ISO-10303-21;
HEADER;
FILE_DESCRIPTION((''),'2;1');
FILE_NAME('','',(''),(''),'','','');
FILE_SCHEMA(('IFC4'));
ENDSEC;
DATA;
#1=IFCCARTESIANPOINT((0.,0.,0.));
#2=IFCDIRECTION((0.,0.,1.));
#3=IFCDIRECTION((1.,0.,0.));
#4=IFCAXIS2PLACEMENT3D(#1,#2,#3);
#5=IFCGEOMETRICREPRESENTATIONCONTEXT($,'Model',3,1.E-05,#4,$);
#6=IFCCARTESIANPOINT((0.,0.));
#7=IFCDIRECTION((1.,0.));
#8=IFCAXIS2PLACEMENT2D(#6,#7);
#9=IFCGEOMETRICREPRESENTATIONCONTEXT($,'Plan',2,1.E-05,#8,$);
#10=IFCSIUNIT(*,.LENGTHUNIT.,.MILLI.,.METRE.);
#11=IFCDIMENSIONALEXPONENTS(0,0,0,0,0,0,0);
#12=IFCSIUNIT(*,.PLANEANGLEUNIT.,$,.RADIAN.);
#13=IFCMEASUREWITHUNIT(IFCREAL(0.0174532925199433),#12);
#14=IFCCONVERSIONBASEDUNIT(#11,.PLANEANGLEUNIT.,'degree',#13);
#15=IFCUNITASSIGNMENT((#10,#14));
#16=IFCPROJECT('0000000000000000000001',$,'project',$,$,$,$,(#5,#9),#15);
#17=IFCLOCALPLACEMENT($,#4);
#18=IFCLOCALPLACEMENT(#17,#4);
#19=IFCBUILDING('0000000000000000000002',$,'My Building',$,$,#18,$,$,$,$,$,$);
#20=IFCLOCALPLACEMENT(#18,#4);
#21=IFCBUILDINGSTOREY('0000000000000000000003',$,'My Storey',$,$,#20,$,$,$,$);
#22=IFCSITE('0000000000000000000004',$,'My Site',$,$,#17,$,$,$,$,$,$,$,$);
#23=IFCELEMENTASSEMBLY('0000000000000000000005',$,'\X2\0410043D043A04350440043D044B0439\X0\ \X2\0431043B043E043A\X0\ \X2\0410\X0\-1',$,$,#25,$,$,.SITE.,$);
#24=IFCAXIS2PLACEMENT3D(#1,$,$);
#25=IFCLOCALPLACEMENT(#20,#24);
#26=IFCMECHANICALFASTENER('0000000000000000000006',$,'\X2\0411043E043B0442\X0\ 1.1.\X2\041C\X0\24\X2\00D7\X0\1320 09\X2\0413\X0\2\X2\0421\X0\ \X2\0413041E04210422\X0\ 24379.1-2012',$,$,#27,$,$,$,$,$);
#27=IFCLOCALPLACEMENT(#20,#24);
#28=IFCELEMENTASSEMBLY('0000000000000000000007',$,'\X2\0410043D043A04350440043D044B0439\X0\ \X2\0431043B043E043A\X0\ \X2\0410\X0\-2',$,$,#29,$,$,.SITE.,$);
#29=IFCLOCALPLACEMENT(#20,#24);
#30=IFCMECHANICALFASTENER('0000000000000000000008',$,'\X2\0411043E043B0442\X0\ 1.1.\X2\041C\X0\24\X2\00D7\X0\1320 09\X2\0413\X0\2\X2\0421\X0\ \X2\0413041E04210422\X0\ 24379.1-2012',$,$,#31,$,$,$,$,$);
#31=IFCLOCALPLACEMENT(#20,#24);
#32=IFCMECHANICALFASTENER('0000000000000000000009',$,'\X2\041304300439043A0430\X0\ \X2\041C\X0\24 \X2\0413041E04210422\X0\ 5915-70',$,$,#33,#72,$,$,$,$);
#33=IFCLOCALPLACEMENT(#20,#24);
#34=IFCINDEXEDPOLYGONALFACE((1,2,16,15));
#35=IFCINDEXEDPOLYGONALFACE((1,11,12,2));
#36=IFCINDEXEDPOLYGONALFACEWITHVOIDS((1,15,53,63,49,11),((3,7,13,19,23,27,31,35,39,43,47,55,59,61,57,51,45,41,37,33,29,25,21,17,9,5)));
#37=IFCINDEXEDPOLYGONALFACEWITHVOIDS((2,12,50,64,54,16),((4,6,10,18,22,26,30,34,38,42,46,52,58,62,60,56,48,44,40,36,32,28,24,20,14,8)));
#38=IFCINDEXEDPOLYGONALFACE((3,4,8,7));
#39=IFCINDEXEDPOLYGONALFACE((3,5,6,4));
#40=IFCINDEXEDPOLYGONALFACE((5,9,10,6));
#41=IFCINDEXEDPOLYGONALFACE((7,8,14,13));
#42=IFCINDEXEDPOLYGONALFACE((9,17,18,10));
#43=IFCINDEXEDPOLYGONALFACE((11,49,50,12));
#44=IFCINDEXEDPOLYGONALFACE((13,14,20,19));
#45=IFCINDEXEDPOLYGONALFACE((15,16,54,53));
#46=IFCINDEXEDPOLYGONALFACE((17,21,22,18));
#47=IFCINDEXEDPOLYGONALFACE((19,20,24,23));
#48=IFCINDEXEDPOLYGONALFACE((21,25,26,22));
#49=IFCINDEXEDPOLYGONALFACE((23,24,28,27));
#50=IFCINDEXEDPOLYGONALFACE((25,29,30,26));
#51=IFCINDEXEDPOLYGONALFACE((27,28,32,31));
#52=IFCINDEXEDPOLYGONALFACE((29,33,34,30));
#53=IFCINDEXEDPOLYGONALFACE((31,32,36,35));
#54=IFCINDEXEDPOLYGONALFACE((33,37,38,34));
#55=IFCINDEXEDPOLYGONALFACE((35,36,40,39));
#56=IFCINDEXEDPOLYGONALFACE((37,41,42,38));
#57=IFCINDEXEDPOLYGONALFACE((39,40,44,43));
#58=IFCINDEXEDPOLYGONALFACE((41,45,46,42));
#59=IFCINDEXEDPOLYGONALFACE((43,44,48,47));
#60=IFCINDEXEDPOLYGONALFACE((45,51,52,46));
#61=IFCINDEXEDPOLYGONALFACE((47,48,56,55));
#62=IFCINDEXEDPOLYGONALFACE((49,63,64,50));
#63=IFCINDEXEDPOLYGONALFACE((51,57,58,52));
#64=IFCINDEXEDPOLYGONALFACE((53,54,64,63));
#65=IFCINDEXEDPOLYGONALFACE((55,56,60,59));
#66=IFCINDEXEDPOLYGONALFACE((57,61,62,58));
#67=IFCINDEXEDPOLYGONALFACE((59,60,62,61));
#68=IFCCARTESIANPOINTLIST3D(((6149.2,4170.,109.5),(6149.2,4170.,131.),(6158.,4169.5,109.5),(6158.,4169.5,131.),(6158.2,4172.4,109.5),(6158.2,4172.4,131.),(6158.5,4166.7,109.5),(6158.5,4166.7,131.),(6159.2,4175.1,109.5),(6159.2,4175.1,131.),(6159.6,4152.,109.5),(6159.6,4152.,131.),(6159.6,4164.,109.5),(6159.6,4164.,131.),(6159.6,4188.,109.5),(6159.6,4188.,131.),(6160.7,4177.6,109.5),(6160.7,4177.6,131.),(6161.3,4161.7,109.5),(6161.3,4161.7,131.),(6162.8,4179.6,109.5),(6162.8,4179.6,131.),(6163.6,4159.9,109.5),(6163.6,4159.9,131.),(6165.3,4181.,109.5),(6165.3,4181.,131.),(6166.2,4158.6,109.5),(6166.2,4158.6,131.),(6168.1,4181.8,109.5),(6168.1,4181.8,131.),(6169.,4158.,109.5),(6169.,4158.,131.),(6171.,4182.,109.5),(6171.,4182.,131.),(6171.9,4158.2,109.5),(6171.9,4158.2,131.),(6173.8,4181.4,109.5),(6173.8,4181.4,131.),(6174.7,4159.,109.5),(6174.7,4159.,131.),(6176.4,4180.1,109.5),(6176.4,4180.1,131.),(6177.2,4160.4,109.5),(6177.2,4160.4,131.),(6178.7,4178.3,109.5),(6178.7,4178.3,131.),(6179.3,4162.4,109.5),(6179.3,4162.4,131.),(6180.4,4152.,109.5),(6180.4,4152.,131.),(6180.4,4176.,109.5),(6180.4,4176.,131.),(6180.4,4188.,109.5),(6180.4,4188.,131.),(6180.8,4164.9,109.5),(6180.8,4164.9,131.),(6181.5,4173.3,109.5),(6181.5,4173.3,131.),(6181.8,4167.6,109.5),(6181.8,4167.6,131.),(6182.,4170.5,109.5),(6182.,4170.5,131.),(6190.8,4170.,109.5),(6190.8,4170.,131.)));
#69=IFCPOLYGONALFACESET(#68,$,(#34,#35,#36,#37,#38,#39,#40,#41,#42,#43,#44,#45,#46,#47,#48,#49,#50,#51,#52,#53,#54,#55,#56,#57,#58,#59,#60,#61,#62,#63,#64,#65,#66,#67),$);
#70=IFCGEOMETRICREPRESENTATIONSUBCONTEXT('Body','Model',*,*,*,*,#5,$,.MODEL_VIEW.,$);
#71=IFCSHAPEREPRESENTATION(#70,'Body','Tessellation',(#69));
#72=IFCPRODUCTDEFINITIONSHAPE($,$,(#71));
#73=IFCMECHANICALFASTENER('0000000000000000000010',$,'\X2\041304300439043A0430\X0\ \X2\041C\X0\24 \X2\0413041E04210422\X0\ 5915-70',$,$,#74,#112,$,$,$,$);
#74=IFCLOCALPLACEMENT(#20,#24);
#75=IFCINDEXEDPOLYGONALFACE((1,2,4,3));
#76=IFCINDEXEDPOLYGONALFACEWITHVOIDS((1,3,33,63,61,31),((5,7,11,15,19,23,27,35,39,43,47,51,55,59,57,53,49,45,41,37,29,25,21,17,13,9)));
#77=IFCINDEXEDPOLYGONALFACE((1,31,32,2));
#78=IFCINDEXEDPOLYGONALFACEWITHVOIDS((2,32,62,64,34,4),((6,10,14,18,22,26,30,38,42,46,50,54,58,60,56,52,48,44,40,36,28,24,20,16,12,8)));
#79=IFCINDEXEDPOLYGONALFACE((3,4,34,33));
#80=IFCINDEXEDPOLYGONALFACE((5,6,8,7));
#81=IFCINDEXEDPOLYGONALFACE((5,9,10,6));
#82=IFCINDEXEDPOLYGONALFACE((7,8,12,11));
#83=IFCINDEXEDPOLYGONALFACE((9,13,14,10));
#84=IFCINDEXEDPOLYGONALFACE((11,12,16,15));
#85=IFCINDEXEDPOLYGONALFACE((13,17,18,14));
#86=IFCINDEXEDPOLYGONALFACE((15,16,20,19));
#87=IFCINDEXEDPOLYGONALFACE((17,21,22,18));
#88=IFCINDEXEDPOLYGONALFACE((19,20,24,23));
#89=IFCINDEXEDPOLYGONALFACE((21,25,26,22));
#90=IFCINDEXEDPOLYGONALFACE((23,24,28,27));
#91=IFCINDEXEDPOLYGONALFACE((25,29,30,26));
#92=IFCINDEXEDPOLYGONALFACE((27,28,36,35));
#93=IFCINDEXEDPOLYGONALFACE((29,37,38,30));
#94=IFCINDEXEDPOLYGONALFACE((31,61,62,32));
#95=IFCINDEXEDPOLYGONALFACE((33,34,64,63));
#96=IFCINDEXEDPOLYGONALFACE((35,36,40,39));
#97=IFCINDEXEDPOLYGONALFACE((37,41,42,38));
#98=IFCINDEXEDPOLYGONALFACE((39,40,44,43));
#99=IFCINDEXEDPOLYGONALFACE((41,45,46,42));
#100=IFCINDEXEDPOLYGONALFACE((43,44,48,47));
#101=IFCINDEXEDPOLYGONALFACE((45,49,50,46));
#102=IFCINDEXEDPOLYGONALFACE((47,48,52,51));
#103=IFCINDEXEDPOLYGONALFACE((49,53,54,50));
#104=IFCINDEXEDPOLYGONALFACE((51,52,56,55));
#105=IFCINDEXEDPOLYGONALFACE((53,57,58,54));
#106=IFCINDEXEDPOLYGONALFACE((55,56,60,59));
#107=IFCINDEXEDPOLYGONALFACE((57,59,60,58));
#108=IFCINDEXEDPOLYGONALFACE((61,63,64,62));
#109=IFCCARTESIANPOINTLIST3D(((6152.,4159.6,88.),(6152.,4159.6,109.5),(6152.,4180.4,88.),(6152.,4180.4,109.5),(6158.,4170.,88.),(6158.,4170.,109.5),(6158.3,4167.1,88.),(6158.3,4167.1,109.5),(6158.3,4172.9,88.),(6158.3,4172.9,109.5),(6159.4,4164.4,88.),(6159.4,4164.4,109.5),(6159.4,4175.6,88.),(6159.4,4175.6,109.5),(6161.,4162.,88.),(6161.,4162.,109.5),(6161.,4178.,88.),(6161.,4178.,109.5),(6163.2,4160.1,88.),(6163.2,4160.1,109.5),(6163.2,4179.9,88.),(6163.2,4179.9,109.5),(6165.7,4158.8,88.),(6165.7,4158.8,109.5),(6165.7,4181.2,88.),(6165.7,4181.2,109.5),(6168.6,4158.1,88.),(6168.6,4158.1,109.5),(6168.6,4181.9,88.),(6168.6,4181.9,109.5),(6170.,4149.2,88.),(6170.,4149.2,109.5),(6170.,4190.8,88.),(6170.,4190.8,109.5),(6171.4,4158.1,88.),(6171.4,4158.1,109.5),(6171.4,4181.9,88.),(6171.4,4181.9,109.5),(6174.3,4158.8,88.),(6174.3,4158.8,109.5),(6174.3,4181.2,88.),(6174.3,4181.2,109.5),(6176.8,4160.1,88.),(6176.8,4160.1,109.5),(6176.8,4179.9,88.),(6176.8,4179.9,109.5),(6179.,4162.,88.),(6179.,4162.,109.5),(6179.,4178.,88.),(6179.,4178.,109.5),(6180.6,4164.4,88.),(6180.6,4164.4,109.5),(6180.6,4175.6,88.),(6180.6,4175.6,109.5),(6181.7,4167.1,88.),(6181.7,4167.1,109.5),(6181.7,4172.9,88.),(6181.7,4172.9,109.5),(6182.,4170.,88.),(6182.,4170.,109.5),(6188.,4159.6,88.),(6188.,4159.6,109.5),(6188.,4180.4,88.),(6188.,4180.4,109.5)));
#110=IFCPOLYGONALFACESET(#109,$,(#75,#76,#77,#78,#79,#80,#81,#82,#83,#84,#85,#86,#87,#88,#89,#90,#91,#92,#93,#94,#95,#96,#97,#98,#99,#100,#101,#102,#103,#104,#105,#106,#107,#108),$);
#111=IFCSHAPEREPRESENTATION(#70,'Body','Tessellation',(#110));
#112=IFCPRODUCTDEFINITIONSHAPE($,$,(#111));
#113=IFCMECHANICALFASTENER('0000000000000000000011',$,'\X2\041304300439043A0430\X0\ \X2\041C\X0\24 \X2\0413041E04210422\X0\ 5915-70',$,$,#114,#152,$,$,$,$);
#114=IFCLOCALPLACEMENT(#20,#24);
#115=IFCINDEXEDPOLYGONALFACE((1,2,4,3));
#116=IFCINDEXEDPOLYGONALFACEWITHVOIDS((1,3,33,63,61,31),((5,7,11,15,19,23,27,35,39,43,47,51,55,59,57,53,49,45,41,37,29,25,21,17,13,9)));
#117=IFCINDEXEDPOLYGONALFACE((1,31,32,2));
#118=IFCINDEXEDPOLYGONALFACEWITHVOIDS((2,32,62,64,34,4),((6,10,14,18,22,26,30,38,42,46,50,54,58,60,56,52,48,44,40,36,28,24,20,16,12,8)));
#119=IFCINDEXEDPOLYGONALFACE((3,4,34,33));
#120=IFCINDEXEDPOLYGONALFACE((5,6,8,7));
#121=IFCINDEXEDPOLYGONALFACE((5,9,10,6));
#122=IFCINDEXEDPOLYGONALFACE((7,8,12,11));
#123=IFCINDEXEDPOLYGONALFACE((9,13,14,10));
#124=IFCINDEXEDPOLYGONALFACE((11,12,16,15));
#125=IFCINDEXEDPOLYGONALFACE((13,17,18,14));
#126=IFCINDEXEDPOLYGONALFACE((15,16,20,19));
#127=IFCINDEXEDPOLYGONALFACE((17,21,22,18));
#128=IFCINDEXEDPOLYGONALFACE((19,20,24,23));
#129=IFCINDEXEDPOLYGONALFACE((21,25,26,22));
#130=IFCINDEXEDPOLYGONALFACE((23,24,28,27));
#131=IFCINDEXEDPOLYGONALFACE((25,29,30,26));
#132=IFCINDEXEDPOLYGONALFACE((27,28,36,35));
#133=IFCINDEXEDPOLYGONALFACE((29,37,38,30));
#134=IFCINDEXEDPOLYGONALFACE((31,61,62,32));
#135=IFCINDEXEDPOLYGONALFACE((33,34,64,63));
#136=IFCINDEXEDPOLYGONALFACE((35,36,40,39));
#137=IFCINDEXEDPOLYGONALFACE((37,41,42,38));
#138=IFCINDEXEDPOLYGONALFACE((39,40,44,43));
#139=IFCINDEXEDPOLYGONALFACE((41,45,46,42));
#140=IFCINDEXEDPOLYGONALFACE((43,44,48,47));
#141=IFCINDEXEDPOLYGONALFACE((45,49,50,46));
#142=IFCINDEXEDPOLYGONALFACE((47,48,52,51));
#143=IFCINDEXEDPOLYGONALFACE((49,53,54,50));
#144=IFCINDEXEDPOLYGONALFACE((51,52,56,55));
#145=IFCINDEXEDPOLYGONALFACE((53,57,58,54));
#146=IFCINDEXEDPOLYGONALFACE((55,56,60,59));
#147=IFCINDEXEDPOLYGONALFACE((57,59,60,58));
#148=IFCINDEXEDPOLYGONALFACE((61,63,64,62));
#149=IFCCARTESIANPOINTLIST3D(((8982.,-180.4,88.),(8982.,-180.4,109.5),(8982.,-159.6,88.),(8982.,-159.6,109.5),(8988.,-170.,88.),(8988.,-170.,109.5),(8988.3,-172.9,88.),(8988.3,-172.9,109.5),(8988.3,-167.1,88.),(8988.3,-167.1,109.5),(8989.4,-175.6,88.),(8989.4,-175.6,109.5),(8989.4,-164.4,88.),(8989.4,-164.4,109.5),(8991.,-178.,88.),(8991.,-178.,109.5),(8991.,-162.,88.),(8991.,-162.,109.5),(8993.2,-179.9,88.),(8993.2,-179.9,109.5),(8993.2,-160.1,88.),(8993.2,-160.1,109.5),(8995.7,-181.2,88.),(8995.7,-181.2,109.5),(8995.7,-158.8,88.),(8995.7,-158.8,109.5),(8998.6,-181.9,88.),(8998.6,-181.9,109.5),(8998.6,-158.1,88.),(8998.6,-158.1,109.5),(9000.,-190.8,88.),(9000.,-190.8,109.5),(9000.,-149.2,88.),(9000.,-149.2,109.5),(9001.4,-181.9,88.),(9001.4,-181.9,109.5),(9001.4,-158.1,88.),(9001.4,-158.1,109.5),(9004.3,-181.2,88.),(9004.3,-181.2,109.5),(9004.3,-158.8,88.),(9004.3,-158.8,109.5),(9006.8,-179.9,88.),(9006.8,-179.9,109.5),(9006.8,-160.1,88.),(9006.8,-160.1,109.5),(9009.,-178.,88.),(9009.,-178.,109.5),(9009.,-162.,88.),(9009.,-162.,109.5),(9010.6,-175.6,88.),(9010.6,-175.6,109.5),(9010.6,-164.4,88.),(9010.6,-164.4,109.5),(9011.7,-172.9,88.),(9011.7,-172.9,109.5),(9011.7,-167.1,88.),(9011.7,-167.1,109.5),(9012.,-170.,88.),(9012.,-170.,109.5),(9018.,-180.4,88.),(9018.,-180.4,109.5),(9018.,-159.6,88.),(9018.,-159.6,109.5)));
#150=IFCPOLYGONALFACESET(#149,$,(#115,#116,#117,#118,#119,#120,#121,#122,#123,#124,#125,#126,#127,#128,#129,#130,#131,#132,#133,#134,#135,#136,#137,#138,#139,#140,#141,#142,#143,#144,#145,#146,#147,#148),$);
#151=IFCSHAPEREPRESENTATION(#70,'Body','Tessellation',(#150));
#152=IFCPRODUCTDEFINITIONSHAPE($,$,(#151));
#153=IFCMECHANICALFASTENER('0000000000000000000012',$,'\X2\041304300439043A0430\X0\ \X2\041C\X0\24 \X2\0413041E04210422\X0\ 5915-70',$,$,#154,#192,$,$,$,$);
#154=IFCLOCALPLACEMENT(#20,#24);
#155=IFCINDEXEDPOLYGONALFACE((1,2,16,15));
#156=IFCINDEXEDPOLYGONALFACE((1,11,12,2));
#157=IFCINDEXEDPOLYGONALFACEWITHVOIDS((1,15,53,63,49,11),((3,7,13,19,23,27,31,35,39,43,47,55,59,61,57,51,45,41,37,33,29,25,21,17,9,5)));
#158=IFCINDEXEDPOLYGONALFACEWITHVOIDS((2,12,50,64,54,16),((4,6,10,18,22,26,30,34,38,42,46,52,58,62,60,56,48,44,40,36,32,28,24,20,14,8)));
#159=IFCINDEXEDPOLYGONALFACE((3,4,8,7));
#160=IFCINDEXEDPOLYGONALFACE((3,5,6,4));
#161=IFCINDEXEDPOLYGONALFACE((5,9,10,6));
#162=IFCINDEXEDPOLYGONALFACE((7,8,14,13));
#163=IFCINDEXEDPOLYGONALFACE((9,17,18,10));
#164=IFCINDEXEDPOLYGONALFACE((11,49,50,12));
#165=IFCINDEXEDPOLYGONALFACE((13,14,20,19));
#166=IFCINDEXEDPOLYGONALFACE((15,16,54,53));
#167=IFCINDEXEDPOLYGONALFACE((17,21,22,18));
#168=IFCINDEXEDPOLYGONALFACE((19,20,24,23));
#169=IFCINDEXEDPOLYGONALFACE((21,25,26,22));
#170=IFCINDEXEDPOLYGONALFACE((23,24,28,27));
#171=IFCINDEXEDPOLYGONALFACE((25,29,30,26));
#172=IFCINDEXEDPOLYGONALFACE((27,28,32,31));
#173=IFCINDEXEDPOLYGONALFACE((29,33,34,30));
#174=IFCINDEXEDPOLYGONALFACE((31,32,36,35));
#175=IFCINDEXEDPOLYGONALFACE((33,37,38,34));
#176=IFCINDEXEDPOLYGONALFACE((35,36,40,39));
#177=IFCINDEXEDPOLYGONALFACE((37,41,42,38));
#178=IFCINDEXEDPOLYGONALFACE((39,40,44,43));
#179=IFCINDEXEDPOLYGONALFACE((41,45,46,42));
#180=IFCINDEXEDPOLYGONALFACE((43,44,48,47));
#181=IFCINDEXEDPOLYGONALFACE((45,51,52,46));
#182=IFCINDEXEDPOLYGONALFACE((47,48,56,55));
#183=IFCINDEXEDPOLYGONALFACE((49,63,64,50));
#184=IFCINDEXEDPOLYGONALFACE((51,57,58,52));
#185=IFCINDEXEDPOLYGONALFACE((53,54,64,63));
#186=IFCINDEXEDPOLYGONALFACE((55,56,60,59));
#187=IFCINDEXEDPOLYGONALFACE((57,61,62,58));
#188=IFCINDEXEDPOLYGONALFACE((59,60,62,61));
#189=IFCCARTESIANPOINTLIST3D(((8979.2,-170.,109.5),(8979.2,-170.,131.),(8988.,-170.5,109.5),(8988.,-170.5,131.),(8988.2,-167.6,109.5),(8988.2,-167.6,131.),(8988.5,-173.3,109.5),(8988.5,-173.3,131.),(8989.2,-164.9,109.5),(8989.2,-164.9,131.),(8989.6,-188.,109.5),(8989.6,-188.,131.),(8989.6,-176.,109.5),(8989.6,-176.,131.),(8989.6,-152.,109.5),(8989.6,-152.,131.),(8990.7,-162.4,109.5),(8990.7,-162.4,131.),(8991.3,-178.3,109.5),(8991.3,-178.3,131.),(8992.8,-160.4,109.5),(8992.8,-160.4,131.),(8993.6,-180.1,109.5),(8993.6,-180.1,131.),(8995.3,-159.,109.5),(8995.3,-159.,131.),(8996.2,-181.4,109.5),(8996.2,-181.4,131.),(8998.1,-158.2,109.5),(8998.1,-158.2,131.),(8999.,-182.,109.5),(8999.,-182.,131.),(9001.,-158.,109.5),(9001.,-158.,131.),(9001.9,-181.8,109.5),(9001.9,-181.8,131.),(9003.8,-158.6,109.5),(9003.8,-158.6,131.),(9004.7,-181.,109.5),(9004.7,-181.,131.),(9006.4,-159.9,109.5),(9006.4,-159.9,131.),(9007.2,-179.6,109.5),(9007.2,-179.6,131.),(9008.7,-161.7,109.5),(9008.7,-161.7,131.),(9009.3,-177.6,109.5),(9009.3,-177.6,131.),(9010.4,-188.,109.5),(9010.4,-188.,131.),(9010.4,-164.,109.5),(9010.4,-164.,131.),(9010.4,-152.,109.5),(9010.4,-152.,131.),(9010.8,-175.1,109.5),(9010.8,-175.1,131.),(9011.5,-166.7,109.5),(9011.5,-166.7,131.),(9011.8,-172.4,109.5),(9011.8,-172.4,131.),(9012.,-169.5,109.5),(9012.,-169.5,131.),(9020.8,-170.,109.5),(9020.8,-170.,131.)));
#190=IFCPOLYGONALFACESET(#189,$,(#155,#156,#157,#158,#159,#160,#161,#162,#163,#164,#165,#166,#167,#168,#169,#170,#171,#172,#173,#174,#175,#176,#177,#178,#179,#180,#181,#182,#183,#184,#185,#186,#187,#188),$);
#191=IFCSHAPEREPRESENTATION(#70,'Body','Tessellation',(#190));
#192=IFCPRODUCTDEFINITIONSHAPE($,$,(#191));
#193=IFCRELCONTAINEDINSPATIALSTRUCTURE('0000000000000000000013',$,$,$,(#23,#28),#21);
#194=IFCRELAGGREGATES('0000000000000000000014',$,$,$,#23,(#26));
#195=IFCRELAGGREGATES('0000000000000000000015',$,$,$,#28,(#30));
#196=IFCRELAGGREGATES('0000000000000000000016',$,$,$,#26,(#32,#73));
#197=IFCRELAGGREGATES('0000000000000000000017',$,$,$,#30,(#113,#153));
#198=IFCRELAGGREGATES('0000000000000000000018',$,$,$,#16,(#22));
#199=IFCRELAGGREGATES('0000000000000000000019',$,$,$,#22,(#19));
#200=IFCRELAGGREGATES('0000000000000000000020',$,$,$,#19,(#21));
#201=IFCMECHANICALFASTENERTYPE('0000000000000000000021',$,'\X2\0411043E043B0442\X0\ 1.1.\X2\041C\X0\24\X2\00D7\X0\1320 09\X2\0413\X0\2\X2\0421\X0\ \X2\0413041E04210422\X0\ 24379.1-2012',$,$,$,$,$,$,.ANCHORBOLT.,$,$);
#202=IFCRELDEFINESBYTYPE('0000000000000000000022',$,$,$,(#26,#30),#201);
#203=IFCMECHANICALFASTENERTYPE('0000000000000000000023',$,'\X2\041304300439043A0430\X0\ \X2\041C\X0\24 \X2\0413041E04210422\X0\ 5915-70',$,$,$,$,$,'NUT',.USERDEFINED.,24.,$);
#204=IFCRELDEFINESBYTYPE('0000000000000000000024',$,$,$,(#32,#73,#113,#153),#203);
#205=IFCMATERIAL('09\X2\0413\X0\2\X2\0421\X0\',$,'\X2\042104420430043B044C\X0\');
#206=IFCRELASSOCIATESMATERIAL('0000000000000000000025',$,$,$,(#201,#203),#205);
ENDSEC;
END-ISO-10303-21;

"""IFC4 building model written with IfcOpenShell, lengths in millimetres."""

from ifc_helpers import new_model, entity, si_unit, converted_unit, frame, origin_with_axes, origin_2d_with_axis, place, context, subcontext, project, spatial, polyline, outline, extrude, source, transform, mapped, material, type_object, type_shapes, element, aggregate, save


model = new_model("IFC4")

# Units and contexts
model_context = context("Model", 3, precision=1e-05, world=origin_with_axes())
plan_context = context("Plan", 2, precision=1e-05, world=origin_2d_with_axis())
body_context = subcontext(model_context, "Body", "Model", "MODEL_VIEW")
ifc_project = project(units=[si_unit("LENGTHUNIT", "METRE", prefix="MILLI"), converted_unit("PLANEANGLEUNIT", "degree", entity("IfcReal", 0.0174532925199433), si_unit("PLANEANGLEUNIT", "RADIAN"), dimensions=[0, 0, 0, 0, 0, 0, 0])], contexts=[model_context, plan_context])

# Site, building, storey
site_placement = place(None, origin_with_axes())
site = spatial("IfcSite", under=ifc_project, at=site_placement, Name="My Site")
building_placement = place(site_placement, origin_with_axes())
building = spatial("IfcBuilding", under=site, at=building_placement, Name="My Building")
storey_placement = place(building_placement, origin_with_axes())
storey = spatial("IfcBuildingStorey", under=building, at=storey_placement, Name="My Storey")

# Element assemblies, mechanical fasteners
assembly_1_placement = place(storey_placement, frame((6000.0, 4000.0, 0.0), z_axis=(0.0, 0.0, 1.0), x_axis=(1.0, 0.0, 0.0)))
assembly_1 = element("IfcElementAssembly", 1, at=assembly_1_placement, inside=storey, Name="Анкерный блок А-1", AssemblyPlace="SITE")
ifc_material_1 = material(Name="09Г2С", Category="Сталь")
mechanical_fastener_type_1 = type_object("IfcMechanicalFastenerType", Name="Болт 1.1.М24×1320 09Г2С ГОСТ 24379.1-2012", PredefinedType="ANCHORBOLT", material=ifc_material_1)
mechanical_fastener_1_placement = place(assembly_1_placement, frame((170.0, 170.0, 0.0), z_axis=(0.0, 0.0, 1.0), x_axis=(-1.0, 0.0, 0.0)))
mechanical_fastener_1 = element("IfcMechanicalFastener", 2, at=mechanical_fastener_1_placement, type_object=mechanical_fastener_type_1, Name="Болт 1.1.М24×1320 09Г2С ГОСТ 24379.1-2012")
aggregate(assembly_1, [mechanical_fastener_1])
assembly_2_placement = place(storey_placement, frame((9000.0, 0.0, 0.0), z_axis=(0.0, 0.0, 1.0), x_axis=(1.0, 0.0, 0.0)))
assembly_2 = element("IfcElementAssembly", 3, at=assembly_2_placement, inside=storey, Name="Анкерный блок А-2", AssemblyPlace="SITE")
mechanical_fastener_2_placement = place(assembly_2_placement, frame((0.0, -170.0, 0.0), z_axis=(0.0, 0.0, 1.0), x_axis=(1.0, 0.0, 0.0)))
mechanical_fastener_2 = element("IfcMechanicalFastener", 4, at=mechanical_fastener_2_placement, type_object=mechanical_fastener_type_1, Name="Болт 1.1.М24×1320 09Г2С ГОСТ 24379.1-2012")
aggregate(assembly_2, [mechanical_fastener_2])
mechanical_fastener_type_2 = type_object("IfcMechanicalFastenerType", Name="Гайка М24 ГОСТ 5915-70", ElementType="NUT", NominalDiameter=24.0, PredefinedType="USERDEFINED", material=ifc_material_1)
shared_shape_1 = source(origin_with_axes(), body_context, "Body", "SweptSolid", [
    extrude(outline(polyline([(-10.4, -18.0), (10.4, -18.0), (20.8, 0.0), (10.4, 18.0), (-10.4, 18.0), (-20.8, 0.0), (-10.4, -18.0)]), holes=[polyline([(-8.0, 9.0), (-5.6, 10.6), (-2.9, 11.7), (0.0, 12.0), (2.9, 11.7), (5.6, 10.6), (8.0, 9.0), (9.9, 6.8), (11.2, 4.3), (11.9, 1.4), (11.9, -1.4), (11.2, -4.3), (9.9, -6.8), (8.0, -9.0), (5.6, -10.6), (2.9, -11.7), (0.0, -12.0), (-2.9, -11.7), (-5.6, -10.6), (-8.0, -9.0), (-9.9, -6.8), (-11.2, -4.3), (-11.9, -1.4), (-11.9, 1.4), (-11.2, 4.3), (-9.9, 6.8), (-8.0, 9.0)])]), frame((0.0, 0.0, 0.0), z_axis=(0.0, 0.0, 1.0), x_axis=(0.0, 1.0, 0.0)), (0.0, 0.0, 1.0), 21.5),
])
type_shapes(mechanical_fastener_type_2, [shared_shape_1])

# Mechanical fasteners
mechanical_fastener_3_placement = place(mechanical_fastener_1_placement, frame((0.0, 0.0, 109.5), z_axis=(0.0, 0.0, 1.0), x_axis=(0.866025, 0.5, 0.0)))
mechanical_fastener_3 = element("IfcMechanicalFastener", 5, at=mechanical_fastener_3_placement, type_object=mechanical_fastener_type_2, Name="Гайка М24 ГОСТ 5915-70", context=body_context, shape_type="MappedRepresentation", body=[
    mapped(shared_shape_1, transform((0.0, 0.0, 0.0), x_axis=(1.0, 0.0, 0.0), y_axis=(0.0, 1.0, 0.0), z_axis=(0.0, 0.0, 1.0), scale=1.0)),
])
mechanical_fastener_4_placement = place(mechanical_fastener_1_placement, frame((0.0, 0.0, 88.0), z_axis=(0.0, 0.0, 1.0), x_axis=(1.0, 0.0, 0.0)))
mechanical_fastener_4 = element("IfcMechanicalFastener", 6, at=mechanical_fastener_4_placement, type_object=mechanical_fastener_type_2, Name="Гайка М24 ГОСТ 5915-70", context=body_context, shape_type="MappedRepresentation", body=[
    mapped(shared_shape_1, transform((0.0, 0.0, 0.0), x_axis=(1.0, 0.0, 0.0), y_axis=(0.0, 1.0, 0.0), z_axis=(0.0, 0.0, 1.0), scale=1.0)),
])
mechanical_fastener_5_placement = place(mechanical_fastener_2_placement, frame((0.0, 0.0, 88.0), z_axis=(0.0, 0.0, 1.0), x_axis=(1.0, 0.0, 0.0)))
mechanical_fastener_5 = element("IfcMechanicalFastener", 7, at=mechanical_fastener_5_placement, type_object=mechanical_fastener_type_2, Name="Гайка М24 ГОСТ 5915-70", context=body_context, shape_type="MappedRepresentation", body=[
    mapped(shared_shape_1, transform((0.0, 0.0, 0.0), x_axis=(1.0, 0.0, 0.0), y_axis=(0.0, 1.0, 0.0), z_axis=(0.0, 0.0, 1.0), scale=1.0)),
])
mechanical_fastener_6_placement = place(mechanical_fastener_2_placement, frame((0.0, 0.0, 109.5), z_axis=(0.0, 0.0, 1.0), x_axis=(0.866025, 0.5, 0.0)))
mechanical_fastener_6 = element("IfcMechanicalFastener", 8, at=mechanical_fastener_6_placement, type_object=mechanical_fastener_type_2, Name="Гайка М24 ГОСТ 5915-70", context=body_context, shape_type="MappedRepresentation", body=[
    mapped(shared_shape_1, transform((0.0, 0.0, 0.0), x_axis=(1.0, 0.0, 0.0), y_axis=(0.0, 1.0, 0.0), z_axis=(0.0, 0.0, 1.0), scale=1.0)),
])
aggregate(mechanical_fastener_1, [mechanical_fastener_3, mechanical_fastener_4])
aggregate(mechanical_fastener_2, [mechanical_fastener_5, mechanical_fastener_6])

save(model, "model.ifc")
